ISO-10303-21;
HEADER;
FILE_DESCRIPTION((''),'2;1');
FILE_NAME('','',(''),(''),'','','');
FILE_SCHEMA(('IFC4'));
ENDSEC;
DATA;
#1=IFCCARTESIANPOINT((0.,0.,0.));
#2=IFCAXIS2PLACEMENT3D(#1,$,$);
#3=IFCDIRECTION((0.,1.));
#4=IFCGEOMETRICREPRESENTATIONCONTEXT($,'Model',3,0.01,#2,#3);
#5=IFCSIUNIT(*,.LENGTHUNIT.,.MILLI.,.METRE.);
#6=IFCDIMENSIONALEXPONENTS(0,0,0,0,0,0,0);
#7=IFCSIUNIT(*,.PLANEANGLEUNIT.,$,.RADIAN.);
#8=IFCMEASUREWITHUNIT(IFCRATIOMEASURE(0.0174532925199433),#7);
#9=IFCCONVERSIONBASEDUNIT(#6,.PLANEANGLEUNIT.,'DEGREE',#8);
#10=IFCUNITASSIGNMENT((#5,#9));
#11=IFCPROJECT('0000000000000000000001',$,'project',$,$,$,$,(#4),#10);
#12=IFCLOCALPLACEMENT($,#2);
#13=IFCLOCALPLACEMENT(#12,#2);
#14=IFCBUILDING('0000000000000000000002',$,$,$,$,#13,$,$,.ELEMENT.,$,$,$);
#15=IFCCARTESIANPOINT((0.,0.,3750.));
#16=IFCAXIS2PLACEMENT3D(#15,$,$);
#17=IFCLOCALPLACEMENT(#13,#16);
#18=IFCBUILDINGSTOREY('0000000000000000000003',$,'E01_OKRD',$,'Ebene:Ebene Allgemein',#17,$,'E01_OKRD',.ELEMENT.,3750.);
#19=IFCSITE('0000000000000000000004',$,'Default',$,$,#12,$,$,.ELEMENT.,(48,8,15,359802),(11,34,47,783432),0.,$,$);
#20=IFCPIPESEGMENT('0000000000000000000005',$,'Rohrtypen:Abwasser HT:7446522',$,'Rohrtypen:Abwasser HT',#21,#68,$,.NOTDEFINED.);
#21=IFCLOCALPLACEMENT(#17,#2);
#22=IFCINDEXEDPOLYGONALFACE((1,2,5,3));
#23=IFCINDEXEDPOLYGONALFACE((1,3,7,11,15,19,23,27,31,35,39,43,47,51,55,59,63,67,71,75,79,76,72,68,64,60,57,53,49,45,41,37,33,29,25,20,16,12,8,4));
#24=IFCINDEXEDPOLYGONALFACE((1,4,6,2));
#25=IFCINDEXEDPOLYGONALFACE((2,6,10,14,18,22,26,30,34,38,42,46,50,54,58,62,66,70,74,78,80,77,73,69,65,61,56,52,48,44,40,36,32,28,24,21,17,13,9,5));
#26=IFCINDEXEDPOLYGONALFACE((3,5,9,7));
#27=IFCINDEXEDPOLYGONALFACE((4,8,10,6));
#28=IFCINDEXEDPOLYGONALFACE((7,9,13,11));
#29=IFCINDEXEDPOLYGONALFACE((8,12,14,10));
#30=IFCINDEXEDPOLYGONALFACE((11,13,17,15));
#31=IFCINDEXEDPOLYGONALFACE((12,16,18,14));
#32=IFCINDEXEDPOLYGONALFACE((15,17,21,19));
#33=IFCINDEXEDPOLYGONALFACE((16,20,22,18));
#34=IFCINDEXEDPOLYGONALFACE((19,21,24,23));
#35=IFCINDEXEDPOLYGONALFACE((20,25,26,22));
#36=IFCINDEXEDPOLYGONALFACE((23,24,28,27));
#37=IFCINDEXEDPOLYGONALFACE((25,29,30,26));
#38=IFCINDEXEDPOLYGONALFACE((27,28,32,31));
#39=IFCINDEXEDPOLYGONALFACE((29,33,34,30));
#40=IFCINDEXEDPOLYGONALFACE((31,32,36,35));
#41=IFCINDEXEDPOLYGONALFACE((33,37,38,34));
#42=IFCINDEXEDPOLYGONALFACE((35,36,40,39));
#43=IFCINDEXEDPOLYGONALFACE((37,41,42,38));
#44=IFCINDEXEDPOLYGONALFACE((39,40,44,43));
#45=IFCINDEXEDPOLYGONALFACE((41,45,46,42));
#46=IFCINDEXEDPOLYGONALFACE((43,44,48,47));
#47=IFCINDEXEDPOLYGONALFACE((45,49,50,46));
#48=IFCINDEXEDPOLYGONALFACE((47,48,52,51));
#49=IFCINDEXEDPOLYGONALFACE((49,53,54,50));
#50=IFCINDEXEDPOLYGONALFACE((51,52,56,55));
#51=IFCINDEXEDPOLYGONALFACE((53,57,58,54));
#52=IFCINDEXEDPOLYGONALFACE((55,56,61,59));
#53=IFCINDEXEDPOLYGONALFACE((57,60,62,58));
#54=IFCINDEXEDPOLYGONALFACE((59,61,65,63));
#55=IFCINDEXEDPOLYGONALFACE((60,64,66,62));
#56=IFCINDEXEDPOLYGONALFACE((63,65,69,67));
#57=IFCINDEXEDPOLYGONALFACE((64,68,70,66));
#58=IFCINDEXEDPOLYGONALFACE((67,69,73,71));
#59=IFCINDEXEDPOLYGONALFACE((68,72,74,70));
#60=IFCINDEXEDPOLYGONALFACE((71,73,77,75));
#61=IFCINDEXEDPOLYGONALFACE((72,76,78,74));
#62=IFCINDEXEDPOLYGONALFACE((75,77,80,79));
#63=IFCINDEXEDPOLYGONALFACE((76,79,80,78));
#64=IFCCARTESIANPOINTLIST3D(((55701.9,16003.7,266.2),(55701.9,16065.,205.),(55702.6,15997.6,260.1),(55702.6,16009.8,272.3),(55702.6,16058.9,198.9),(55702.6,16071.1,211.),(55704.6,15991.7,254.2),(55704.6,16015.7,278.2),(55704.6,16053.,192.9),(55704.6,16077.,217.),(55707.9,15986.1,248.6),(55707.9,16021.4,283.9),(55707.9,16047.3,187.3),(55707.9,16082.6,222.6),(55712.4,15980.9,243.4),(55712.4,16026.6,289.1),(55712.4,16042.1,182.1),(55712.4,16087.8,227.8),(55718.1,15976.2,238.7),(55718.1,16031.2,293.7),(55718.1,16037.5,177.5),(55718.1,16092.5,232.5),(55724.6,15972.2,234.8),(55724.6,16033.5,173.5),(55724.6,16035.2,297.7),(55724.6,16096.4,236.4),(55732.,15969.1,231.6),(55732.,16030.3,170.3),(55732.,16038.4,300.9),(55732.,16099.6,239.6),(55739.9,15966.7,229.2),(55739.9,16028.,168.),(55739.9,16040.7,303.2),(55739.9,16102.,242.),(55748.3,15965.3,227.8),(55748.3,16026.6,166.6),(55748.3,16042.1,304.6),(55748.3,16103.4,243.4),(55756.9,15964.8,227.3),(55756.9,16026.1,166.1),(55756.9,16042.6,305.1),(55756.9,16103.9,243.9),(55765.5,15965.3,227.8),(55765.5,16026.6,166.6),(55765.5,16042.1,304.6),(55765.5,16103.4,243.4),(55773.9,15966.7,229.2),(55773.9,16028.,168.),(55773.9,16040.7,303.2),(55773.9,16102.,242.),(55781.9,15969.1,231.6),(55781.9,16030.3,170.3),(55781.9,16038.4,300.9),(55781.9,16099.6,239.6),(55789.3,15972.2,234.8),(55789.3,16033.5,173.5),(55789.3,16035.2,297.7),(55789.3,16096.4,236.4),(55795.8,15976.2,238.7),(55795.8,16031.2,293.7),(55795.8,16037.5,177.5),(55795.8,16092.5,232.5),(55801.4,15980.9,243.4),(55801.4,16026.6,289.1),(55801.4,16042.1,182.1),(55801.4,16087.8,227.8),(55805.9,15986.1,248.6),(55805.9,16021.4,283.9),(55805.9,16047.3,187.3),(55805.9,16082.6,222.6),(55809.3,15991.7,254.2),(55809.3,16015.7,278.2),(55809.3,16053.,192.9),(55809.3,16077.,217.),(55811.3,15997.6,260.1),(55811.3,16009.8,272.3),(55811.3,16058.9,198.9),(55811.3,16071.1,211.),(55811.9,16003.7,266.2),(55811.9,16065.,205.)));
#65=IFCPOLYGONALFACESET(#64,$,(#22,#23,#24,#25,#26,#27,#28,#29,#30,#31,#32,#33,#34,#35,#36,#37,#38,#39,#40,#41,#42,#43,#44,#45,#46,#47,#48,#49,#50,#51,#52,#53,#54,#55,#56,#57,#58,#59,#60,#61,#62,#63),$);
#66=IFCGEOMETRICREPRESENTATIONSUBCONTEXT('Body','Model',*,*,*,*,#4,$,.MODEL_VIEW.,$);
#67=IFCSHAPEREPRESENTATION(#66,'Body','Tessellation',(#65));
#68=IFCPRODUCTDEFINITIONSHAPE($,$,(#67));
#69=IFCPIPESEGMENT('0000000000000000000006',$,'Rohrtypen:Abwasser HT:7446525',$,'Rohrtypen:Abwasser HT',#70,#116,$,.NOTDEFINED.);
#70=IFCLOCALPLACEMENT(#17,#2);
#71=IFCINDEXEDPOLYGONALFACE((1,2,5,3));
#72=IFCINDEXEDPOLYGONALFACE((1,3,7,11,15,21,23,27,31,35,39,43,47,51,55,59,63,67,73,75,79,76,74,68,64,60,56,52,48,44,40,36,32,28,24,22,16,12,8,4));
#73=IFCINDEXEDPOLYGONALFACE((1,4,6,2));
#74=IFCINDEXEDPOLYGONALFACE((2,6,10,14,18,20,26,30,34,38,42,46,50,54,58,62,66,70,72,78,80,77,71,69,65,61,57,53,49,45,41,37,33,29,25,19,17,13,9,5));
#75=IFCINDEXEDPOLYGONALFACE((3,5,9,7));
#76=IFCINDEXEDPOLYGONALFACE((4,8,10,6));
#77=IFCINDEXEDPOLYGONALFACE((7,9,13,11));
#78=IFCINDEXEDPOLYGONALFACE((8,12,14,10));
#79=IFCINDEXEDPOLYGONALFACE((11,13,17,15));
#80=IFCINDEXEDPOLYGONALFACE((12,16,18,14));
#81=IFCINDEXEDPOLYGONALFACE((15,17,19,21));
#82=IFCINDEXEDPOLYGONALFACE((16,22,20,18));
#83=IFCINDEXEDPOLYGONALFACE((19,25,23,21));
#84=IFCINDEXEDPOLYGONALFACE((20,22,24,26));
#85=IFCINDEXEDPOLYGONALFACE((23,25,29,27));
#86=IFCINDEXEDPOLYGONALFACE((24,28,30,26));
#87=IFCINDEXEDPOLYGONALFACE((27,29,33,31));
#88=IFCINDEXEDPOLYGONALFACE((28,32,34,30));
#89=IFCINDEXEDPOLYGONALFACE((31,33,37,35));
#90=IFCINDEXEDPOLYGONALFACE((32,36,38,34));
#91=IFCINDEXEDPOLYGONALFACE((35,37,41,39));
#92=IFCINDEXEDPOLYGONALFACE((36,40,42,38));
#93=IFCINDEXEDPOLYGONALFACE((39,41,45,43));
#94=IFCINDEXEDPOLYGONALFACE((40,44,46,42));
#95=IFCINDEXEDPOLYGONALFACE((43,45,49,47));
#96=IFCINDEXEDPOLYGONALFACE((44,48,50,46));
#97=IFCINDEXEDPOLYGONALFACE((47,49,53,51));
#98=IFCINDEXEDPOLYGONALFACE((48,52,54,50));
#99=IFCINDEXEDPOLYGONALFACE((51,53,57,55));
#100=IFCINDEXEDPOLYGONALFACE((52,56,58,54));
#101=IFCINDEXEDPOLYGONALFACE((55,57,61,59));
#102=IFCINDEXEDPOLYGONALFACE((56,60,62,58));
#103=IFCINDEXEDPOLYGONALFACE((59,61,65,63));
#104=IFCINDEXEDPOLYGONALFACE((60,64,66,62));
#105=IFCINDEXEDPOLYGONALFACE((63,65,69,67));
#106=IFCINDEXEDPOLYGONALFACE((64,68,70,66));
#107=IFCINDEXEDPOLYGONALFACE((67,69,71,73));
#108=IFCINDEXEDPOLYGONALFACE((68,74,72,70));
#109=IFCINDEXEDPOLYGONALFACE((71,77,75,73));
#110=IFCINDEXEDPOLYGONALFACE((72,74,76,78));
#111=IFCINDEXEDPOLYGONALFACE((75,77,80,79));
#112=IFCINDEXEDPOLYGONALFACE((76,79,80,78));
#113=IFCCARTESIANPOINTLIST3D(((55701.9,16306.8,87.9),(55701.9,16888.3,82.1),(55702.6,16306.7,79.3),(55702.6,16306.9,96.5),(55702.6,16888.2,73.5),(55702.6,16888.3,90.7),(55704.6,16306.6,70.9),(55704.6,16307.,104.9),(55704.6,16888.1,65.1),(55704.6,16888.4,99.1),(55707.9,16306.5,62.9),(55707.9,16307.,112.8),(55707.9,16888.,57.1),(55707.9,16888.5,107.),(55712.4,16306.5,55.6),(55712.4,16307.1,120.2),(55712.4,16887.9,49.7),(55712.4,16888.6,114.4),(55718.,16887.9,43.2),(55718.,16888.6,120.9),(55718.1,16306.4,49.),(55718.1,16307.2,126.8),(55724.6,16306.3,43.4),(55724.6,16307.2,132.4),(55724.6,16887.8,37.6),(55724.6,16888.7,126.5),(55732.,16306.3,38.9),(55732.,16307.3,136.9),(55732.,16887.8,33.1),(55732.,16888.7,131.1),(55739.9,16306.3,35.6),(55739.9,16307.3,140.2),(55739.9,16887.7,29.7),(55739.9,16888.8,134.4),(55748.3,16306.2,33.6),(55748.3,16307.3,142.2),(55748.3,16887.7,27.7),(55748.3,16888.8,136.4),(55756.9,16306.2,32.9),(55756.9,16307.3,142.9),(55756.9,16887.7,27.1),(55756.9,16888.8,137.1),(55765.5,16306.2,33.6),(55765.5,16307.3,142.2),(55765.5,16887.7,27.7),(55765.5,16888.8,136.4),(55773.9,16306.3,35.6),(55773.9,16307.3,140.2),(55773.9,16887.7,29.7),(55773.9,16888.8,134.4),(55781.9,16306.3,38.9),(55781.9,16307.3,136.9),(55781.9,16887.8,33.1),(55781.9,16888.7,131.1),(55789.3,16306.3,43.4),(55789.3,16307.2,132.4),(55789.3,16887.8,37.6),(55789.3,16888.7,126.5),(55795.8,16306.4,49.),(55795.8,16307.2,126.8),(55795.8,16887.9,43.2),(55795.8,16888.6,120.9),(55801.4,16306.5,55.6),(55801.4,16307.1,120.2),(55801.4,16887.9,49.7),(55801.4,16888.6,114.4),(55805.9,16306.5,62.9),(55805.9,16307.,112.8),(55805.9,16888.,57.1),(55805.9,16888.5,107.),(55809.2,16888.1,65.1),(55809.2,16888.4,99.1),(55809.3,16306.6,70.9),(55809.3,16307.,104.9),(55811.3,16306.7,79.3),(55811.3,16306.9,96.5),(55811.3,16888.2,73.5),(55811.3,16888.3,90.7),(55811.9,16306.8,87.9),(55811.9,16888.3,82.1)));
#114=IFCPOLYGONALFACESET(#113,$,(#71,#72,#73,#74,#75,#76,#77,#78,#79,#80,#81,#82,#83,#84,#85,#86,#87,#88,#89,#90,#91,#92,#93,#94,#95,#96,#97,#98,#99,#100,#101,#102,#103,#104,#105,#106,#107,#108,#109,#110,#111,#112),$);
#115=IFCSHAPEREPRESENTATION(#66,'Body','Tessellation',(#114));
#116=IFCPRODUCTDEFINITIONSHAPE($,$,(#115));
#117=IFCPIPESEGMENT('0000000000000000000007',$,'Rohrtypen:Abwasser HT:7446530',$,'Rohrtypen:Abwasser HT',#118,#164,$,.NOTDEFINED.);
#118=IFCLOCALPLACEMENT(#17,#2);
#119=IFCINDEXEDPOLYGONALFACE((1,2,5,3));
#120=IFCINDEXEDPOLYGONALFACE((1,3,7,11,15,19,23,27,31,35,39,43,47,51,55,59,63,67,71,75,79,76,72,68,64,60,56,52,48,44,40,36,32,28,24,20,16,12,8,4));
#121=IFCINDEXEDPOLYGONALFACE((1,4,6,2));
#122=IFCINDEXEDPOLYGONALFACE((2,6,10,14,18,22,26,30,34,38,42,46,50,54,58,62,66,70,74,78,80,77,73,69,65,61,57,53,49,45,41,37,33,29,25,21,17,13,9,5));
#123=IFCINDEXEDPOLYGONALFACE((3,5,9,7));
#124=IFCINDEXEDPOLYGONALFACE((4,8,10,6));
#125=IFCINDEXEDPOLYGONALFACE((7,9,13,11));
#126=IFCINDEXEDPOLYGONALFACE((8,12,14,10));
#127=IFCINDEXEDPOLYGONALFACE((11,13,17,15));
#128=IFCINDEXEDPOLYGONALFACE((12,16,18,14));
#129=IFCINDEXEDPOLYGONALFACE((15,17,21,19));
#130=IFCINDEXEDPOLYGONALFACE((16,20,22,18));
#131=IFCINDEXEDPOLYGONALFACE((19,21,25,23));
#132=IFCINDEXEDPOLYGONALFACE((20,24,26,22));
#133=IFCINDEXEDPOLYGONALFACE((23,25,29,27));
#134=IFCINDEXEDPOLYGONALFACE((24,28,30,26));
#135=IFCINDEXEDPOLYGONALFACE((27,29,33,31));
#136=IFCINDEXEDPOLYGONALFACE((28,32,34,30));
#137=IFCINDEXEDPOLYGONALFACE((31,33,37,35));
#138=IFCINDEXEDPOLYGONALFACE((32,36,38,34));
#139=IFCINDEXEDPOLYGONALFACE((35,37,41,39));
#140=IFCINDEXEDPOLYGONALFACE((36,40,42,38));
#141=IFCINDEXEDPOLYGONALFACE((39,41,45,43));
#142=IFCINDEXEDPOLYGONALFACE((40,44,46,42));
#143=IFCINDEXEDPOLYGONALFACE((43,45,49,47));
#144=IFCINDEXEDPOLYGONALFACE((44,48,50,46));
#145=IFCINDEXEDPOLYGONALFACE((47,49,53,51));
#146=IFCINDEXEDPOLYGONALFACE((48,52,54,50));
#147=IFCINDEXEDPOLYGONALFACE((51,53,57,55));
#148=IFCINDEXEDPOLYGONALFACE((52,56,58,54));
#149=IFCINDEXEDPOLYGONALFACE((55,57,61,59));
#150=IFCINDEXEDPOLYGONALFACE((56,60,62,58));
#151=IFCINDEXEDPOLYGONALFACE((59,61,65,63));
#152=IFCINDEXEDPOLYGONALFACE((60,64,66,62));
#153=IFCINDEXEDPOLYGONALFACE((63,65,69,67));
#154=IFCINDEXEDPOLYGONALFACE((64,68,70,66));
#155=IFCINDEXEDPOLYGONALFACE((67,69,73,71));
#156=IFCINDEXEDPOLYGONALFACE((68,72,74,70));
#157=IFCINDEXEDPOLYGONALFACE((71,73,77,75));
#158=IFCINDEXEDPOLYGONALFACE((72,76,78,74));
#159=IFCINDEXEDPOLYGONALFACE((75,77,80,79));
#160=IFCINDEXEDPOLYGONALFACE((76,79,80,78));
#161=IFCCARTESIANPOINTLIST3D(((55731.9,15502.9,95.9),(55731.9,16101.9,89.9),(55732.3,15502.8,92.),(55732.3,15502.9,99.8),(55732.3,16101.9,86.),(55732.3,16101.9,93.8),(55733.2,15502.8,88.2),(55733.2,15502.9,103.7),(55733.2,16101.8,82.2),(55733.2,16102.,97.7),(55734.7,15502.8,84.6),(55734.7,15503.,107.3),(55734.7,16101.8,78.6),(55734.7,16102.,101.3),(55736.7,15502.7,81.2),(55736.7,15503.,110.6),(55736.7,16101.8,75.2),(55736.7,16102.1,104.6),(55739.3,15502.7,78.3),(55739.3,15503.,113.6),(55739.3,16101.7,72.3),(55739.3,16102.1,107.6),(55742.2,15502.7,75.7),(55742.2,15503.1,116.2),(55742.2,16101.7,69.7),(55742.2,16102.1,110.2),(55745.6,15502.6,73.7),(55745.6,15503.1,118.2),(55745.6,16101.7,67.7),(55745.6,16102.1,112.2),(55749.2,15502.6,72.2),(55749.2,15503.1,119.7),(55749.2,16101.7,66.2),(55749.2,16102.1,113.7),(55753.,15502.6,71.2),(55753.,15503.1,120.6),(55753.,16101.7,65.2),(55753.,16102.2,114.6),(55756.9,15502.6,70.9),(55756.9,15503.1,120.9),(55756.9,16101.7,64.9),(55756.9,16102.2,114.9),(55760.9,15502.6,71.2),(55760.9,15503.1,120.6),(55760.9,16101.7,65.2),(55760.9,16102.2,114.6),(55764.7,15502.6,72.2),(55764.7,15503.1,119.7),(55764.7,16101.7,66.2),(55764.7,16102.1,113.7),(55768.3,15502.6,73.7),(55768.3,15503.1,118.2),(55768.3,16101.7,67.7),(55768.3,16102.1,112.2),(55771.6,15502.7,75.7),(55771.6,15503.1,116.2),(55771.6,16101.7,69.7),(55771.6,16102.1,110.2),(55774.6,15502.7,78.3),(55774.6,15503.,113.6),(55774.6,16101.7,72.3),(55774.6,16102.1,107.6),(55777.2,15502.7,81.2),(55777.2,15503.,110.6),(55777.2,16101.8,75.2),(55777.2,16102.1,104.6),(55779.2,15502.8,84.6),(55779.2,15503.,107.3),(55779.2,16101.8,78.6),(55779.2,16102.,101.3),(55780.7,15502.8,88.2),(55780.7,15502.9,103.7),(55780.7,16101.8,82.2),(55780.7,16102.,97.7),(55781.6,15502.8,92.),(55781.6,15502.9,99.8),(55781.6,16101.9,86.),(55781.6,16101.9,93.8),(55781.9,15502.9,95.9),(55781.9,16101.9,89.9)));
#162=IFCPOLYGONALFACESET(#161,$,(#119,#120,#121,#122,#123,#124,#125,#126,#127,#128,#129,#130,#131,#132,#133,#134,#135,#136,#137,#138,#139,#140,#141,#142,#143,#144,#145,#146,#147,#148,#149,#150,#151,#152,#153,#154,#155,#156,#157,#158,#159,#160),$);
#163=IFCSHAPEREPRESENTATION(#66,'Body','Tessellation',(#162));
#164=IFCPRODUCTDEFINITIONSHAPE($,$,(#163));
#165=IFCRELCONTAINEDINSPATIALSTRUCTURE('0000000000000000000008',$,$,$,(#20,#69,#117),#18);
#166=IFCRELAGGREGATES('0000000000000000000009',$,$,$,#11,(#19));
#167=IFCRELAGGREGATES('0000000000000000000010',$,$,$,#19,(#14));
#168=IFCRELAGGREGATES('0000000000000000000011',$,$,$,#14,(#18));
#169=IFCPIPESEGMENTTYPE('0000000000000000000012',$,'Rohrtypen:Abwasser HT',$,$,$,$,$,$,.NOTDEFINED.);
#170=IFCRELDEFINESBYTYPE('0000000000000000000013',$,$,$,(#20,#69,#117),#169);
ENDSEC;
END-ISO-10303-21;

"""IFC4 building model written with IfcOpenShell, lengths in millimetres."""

from ifc_helpers import new_model, entity, si_unit, converted_unit, direction, frame, origin, place, context, subcontext, project, spatial, indexed_curve, outline, extrude, type_object, element, save


model = new_model("IFC4")

# Units and contexts
model_context = context("Model", 3, precision=0.01, world=origin(), true_north=direction((0.0, 1.0)))
body_context = subcontext(model_context, "Body", "Model", "MODEL_VIEW")
ifc_project = project(units=[si_unit("LENGTHUNIT", "METRE", prefix="MILLI"), converted_unit("PLANEANGLEUNIT", "DEGREE", entity("IfcRatioMeasure", 0.0174532925199433), si_unit("PLANEANGLEUNIT", "RADIAN"), dimensions=[0, 0, 0, 0, 0, 0, 0])], contexts=[model_context])

# Site, building, storey
site_placement = place(None, origin())
site = spatial("IfcSite", under=ifc_project, at=site_placement, Name="Default", CompositionType="ELEMENT", RefLatitude=(48, 8, 15, 359802), RefLongitude=(11, 34, 47, 783432), RefElevation=0.0)
building_placement = place(site_placement, origin())
building = spatial("IfcBuilding", under=site, at=building_placement, CompositionType="ELEMENT")
storey_placement = place(building_placement, frame((0.0, 0.0, 3750.0)))
storey = spatial("IfcBuildingStorey", under=building, at=storey_placement, Name="E01_OKRD", ObjectType="Ebene:Ebene Allgemein", LongName="E01_OKRD", CompositionType="ELEMENT", Elevation=3750.0)

# Pipe segments
pipe_segment_type_1 = type_object("IfcPipeSegmentType", Name="Rohrtypen:Abwasser HT", PredefinedType="NOTDEFINED")
pipe_segment_1_placement = place(storey_placement, origin())
element("IfcPipeSegment", 1, at=pipe_segment_1_placement, inside=storey, type_object=pipe_segment_type_1, Name="Rohrtypen:Abwasser HT:7446522", ObjectType="Rohrtypen:Abwasser HT", PredefinedType="NOTDEFINED", context=body_context, shape_type="SweptSolid", body=[
    extrude(outline(indexed_curve([(55.0, 0.0), (54.3, 8.6), (52.3, 17.0), (49.0, 25.0), (44.5, 32.3), (38.9, 38.9), (32.3, 44.5), (25.0, 49.0), (17.0, 52.3), (8.6, 54.3), (0.0, 55.0), (-8.6, 54.3), (-17.0, 52.3), (-25.0, 49.0), (-32.3, 44.5), (-38.9, 38.9), (-44.5, 32.3), (-49.0, 25.0), (-52.3, 17.0), (-54.3, 8.6), (-55.0, 0.0), (-54.3, -8.6), (-52.3, -17.0), (-49.0, -25.0), (-44.5, -32.3), (-38.9, -38.9), (-32.3, -44.5), (-25.0, -49.0), (-17.0, -52.3), (-8.6, -54.3), (0.0, -55.0), (8.6, -54.3), (17.0, -52.3), (25.0, -49.0), (32.3, -44.5), (38.9, -38.9), (44.5, -32.3), (49.0, -25.0), (52.3, -17.0), (54.3, -8.6), (55.0, 0.0)], self_intersect=False)), frame((55756.9, 16003.7, 266.2), z_axis=(0.0, 0.707107, -0.707107), x_axis=(-1.0, 0.0, 0.0)), (0.0, 0.0, 1.0), 86.6),
])
pipe_segment_2_placement = place(storey_placement, origin())
element("IfcPipeSegment", 2, at=pipe_segment_2_placement, inside=storey, type_object=pipe_segment_type_1, Name="Rohrtypen:Abwasser HT:7446525", ObjectType="Rohrtypen:Abwasser HT", PredefinedType="NOTDEFINED", context=body_context, shape_type="SweptSolid", body=[
    extrude(outline(indexed_curve([(55.0, 0.0), (54.3, 8.6), (52.3, 17.0), (49.0, 25.0), (44.5, 32.3), (38.9, 38.9), (32.3, 44.5), (25.0, 49.0), (17.0, 52.3), (8.6, 54.3), (0.0, 55.0), (-8.6, 54.3), (-17.0, 52.3), (-25.0, 49.0), (-32.3, 44.5), (-38.9, 38.9), (-44.5, 32.3), (-49.0, 25.0), (-52.3, 17.0), (-54.3, 8.6), (-55.0, 0.0), (-54.3, -8.6), (-52.3, -17.0), (-49.0, -25.0), (-44.5, -32.3), (-38.9, -38.9), (-32.3, -44.5), (-25.0, -49.0), (-17.0, -52.3), (-8.6, -54.3), (0.0, -55.0), (8.6, -54.3), (17.0, -52.3), (25.0, -49.0), (32.3, -44.5), (38.9, -38.9), (44.5, -32.3), (49.0, -25.0), (52.3, -17.0), (54.3, -8.6), (55.0, 0.0)], self_intersect=False)), frame((55756.9, 16888.3, 82.1), z_axis=(0.000006, -0.99995, 0.010016), x_axis=(-1.0, -0.000006, 0.0)), (0.0, 0.0, 1.0), 581.5),
])
pipe_segment_3_placement = place(storey_placement, origin())
element("IfcPipeSegment", 3, at=pipe_segment_3_placement, inside=storey, type_object=pipe_segment_type_1, Name="Rohrtypen:Abwasser HT:7446530", ObjectType="Rohrtypen:Abwasser HT", PredefinedType="NOTDEFINED", context=body_context, shape_type="SweptSolid", body=[
    extrude(outline(indexed_curve([(25.0, 0.0), (24.7, 3.9), (23.8, 7.7), (22.3, 11.3), (20.2, 14.7), (17.7, 17.7), (14.7, 20.2), (11.3, 22.3), (7.7, 23.8), (3.9, 24.7), (0.0, 25.0), (-3.9, 24.7), (-7.7, 23.8), (-11.3, 22.3), (-14.7, 20.2), (-17.7, 17.7), (-20.2, 14.7), (-22.3, 11.3), (-23.8, 7.7), (-24.7, 3.9), (-25.0, 0.0), (-24.7, -3.9), (-23.8, -7.7), (-22.3, -11.3), (-20.2, -14.7), (-17.7, -17.7), (-14.7, -20.2), (-11.3, -22.3), (-7.7, -23.8), (-3.9, -24.7), (0.0, -25.0), (3.9, -24.7), (7.7, -23.8), (11.3, -22.3), (14.7, -20.2), (17.7, -17.7), (20.2, -14.7), (22.3, -11.3), (23.8, -7.7), (24.7, -3.9), (25.0, 0.0)], self_intersect=False)), frame((55756.9, 15502.9, 95.9), z_axis=(0.0, 0.99995, -0.010016), x_axis=(-1.0, 0.0, 0.0)), (0.0, 0.0, 1.0), 599.1),
])

save(model, "model.ifc")
